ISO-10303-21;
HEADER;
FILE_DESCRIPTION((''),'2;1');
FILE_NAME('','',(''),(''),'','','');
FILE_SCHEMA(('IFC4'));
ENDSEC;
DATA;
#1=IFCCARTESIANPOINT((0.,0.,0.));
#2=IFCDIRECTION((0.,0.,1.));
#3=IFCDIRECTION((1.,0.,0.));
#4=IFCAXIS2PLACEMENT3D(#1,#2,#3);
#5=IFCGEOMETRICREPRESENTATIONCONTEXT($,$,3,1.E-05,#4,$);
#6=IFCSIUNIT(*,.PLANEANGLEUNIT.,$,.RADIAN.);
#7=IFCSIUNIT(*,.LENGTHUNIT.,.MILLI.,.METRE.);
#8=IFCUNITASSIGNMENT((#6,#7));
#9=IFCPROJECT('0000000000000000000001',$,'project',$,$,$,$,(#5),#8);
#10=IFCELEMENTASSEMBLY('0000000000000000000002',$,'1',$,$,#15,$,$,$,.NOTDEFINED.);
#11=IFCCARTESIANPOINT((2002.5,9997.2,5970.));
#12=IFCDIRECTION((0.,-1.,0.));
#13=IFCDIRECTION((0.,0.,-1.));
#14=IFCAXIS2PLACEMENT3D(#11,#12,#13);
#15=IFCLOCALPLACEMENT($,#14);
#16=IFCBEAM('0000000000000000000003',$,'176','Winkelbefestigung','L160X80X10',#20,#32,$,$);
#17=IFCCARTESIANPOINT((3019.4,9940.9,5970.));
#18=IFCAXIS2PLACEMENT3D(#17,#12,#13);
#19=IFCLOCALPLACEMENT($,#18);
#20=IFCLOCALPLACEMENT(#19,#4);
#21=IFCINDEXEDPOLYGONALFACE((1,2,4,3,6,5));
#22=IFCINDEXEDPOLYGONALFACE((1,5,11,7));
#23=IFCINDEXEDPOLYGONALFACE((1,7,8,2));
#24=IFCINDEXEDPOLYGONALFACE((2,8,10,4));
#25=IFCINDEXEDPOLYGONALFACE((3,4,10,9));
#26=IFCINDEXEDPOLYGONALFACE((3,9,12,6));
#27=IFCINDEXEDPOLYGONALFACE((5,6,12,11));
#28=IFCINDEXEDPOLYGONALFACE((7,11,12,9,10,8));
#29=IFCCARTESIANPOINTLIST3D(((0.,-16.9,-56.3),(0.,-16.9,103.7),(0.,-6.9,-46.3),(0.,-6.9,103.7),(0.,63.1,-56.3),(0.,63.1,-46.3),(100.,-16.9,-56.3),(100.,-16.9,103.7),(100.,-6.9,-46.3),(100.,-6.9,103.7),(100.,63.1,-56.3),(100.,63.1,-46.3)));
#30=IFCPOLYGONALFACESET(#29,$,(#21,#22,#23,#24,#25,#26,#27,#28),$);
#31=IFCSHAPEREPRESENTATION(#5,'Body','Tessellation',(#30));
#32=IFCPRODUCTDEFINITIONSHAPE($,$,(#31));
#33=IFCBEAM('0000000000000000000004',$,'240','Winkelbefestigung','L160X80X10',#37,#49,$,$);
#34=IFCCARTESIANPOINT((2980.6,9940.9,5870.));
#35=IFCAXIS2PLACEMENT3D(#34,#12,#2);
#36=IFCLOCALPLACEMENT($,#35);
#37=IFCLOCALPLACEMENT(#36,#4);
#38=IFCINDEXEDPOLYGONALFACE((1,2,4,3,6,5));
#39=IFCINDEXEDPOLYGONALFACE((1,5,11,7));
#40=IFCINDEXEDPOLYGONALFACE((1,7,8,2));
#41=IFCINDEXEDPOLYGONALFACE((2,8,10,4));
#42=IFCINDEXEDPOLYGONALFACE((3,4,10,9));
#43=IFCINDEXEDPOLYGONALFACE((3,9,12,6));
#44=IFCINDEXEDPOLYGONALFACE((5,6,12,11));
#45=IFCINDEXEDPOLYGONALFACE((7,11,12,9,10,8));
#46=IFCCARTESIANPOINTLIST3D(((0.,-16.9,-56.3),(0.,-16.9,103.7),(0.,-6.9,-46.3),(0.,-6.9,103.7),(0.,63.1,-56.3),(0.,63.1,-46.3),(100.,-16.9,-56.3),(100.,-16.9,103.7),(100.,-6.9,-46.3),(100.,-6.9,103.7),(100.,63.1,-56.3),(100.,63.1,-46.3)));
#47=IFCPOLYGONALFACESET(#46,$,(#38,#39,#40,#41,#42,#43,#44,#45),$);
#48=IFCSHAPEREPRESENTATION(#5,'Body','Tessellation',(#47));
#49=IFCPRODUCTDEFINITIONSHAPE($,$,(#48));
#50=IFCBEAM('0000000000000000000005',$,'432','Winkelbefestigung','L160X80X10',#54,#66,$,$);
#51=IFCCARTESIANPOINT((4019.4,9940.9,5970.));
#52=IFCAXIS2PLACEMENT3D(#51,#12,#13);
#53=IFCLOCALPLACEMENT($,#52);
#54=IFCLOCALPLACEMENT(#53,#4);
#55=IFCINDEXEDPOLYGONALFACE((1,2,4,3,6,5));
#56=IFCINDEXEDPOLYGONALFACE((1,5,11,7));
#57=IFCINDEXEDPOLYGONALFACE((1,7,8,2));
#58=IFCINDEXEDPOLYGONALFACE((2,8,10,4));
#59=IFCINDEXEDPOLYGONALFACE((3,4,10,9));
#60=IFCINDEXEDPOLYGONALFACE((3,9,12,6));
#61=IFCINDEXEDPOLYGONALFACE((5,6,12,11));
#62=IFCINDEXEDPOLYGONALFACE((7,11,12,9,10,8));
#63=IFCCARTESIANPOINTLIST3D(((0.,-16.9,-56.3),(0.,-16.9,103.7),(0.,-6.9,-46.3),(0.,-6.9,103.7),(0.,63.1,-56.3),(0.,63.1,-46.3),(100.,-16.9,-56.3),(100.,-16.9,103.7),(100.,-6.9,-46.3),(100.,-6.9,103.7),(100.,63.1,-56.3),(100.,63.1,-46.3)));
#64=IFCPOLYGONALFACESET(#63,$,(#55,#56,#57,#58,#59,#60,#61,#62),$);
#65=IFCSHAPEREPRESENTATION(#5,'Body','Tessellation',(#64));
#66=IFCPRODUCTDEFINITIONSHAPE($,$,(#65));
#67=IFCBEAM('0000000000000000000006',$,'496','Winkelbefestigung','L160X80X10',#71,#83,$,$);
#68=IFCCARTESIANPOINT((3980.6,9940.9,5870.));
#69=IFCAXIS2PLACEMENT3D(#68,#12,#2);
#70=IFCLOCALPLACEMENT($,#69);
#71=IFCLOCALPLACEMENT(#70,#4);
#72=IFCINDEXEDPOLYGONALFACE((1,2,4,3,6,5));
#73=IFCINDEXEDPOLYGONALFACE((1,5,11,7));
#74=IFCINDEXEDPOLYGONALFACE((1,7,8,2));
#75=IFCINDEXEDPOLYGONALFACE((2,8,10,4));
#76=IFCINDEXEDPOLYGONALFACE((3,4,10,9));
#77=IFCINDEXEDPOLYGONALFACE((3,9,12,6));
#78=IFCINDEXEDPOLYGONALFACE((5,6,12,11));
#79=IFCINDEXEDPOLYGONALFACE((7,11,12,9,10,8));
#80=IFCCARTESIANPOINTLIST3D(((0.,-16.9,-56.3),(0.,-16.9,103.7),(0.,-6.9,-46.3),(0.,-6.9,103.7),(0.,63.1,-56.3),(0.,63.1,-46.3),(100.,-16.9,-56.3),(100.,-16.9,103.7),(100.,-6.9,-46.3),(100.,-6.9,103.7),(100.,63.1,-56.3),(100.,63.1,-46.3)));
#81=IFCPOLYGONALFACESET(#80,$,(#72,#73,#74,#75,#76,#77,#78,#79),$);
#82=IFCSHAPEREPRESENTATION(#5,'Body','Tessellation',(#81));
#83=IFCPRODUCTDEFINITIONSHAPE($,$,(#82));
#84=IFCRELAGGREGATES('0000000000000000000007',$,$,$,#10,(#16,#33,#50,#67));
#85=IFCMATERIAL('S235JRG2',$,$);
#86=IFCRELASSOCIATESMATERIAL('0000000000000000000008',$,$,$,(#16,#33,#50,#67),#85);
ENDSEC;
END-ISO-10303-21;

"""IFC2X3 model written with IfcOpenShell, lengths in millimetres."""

from ifc_helpers import new_model, si_unit, frame, origin_with_axes, place, context, project, polyline, outline, extrude, material, element, aggregate, save


model = new_model("IFC2X3")

# Units and contexts
context_of_model = context(None, 3, precision=1e-05, world=origin_with_axes())
ifc_project = project(units=[si_unit("PLANEANGLEUNIT", "RADIAN"), si_unit("LENGTHUNIT", "METRE", prefix="MILLI")], contexts=[context_of_model])

# Shared definitions
ifc_material = material(Name="S235JRG2")

# Element assembly, beams
assembly_1_placement = place(None, frame((2002.5, 9997.2, 5970.0), z_axis=(0.0, -1.0, 0.0), x_axis=(0.0, 0.0, -1.0)))
assembly_1 = element("IfcElementAssembly", 1, at=assembly_1_placement, Name="1", PredefinedType="NOTDEFINED")
placement_1 = place(None, frame((3019.4, 9940.9, 5970.0), z_axis=(0.0, -1.0, 0.0), x_axis=(0.0, 0.0, -1.0)))
beam_1_placement = place(placement_1, origin_with_axes())
beam_1 = element("IfcBeam", 2, at=beam_1_placement, material=ifc_material, Name="176", Description="Winkelbefestigung", ObjectType="L160X80X10", context=context_of_model, shape_type="SweptSolid", body=[
    extrude(outline(polyline([(-16.9, 103.7), (-16.9, -56.3), (63.1, -56.3), (63.1, -46.3), (-6.9, -46.3), (-6.9, 103.7), (-16.9, 103.7), (-16.9, 103.7)])), frame((0.0, 0.0, 0.0), z_axis=(1.0, 0.0, 0.0), x_axis=(0.0, 1.0, 0.0)), (0.0, 0.0, 1.0), 100.0),
])
placement_2 = place(None, frame((2980.6, 9940.9, 5870.0), z_axis=(0.0, -1.0, 0.0), x_axis=(0.0, 0.0, 1.0)))
beam_2_placement = place(placement_2, origin_with_axes())
beam_2 = element("IfcBeam", 3, at=beam_2_placement, material=ifc_material, Name="240", Description="Winkelbefestigung", ObjectType="L160X80X10", context=context_of_model, shape_type="SweptSolid", body=[
    extrude(outline(polyline([(-16.9, 103.7), (-16.9, -56.3), (63.1, -56.3), (63.1, -46.3), (-6.9, -46.3), (-6.9, 103.7), (-16.9, 103.7), (-16.9, 103.7)])), frame((0.0, 0.0, 0.0), z_axis=(1.0, 0.0, 0.0), x_axis=(0.0, 1.0, 0.0)), (0.0, 0.0, 1.0), 100.0),
])
placement_3 = place(None, frame((4019.4, 9940.9, 5970.0), z_axis=(0.0, -1.0, 0.0), x_axis=(0.0, 0.0, -1.0)))
beam_3_placement = place(placement_3, origin_with_axes())
beam_3 = element("IfcBeam", 4, at=beam_3_placement, material=ifc_material, Name="432", Description="Winkelbefestigung", ObjectType="L160X80X10", context=context_of_model, shape_type="SweptSolid", body=[
    extrude(outline(polyline([(-16.9, 103.7), (-16.9, -56.3), (63.1, -56.3), (63.1, -46.3), (-6.9, -46.3), (-6.9, 103.7), (-16.9, 103.7), (-16.9, 103.7)])), frame((0.0, 0.0, 0.0), z_axis=(1.0, 0.0, 0.0), x_axis=(0.0, 1.0, 0.0)), (0.0, 0.0, 1.0), 100.0),
])
placement_4 = place(None, frame((3980.6, 9940.9, 5870.0), z_axis=(0.0, -1.0, 0.0), x_axis=(0.0, 0.0, 1.0)))
beam_4_placement = place(placement_4, origin_with_axes())
beam_4 = element("IfcBeam", 5, at=beam_4_placement, material=ifc_material, Name="496", Description="Winkelbefestigung", ObjectType="L160X80X10", context=context_of_model, shape_type="SweptSolid", body=[
    extrude(outline(polyline([(-16.9, 103.7), (-16.9, -56.3), (63.1, -56.3), (63.1, -46.3), (-6.9, -46.3), (-6.9, 103.7), (-16.9, 103.7), (-16.9, 103.7)])), frame((0.0, 0.0, 0.0), z_axis=(1.0, 0.0, 0.0), x_axis=(0.0, 1.0, 0.0)), (0.0, 0.0, 1.0), 100.0),
])
aggregate(assembly_1, [beam_1, beam_2, beam_3, beam_4])

save(model, "model.ifc")
